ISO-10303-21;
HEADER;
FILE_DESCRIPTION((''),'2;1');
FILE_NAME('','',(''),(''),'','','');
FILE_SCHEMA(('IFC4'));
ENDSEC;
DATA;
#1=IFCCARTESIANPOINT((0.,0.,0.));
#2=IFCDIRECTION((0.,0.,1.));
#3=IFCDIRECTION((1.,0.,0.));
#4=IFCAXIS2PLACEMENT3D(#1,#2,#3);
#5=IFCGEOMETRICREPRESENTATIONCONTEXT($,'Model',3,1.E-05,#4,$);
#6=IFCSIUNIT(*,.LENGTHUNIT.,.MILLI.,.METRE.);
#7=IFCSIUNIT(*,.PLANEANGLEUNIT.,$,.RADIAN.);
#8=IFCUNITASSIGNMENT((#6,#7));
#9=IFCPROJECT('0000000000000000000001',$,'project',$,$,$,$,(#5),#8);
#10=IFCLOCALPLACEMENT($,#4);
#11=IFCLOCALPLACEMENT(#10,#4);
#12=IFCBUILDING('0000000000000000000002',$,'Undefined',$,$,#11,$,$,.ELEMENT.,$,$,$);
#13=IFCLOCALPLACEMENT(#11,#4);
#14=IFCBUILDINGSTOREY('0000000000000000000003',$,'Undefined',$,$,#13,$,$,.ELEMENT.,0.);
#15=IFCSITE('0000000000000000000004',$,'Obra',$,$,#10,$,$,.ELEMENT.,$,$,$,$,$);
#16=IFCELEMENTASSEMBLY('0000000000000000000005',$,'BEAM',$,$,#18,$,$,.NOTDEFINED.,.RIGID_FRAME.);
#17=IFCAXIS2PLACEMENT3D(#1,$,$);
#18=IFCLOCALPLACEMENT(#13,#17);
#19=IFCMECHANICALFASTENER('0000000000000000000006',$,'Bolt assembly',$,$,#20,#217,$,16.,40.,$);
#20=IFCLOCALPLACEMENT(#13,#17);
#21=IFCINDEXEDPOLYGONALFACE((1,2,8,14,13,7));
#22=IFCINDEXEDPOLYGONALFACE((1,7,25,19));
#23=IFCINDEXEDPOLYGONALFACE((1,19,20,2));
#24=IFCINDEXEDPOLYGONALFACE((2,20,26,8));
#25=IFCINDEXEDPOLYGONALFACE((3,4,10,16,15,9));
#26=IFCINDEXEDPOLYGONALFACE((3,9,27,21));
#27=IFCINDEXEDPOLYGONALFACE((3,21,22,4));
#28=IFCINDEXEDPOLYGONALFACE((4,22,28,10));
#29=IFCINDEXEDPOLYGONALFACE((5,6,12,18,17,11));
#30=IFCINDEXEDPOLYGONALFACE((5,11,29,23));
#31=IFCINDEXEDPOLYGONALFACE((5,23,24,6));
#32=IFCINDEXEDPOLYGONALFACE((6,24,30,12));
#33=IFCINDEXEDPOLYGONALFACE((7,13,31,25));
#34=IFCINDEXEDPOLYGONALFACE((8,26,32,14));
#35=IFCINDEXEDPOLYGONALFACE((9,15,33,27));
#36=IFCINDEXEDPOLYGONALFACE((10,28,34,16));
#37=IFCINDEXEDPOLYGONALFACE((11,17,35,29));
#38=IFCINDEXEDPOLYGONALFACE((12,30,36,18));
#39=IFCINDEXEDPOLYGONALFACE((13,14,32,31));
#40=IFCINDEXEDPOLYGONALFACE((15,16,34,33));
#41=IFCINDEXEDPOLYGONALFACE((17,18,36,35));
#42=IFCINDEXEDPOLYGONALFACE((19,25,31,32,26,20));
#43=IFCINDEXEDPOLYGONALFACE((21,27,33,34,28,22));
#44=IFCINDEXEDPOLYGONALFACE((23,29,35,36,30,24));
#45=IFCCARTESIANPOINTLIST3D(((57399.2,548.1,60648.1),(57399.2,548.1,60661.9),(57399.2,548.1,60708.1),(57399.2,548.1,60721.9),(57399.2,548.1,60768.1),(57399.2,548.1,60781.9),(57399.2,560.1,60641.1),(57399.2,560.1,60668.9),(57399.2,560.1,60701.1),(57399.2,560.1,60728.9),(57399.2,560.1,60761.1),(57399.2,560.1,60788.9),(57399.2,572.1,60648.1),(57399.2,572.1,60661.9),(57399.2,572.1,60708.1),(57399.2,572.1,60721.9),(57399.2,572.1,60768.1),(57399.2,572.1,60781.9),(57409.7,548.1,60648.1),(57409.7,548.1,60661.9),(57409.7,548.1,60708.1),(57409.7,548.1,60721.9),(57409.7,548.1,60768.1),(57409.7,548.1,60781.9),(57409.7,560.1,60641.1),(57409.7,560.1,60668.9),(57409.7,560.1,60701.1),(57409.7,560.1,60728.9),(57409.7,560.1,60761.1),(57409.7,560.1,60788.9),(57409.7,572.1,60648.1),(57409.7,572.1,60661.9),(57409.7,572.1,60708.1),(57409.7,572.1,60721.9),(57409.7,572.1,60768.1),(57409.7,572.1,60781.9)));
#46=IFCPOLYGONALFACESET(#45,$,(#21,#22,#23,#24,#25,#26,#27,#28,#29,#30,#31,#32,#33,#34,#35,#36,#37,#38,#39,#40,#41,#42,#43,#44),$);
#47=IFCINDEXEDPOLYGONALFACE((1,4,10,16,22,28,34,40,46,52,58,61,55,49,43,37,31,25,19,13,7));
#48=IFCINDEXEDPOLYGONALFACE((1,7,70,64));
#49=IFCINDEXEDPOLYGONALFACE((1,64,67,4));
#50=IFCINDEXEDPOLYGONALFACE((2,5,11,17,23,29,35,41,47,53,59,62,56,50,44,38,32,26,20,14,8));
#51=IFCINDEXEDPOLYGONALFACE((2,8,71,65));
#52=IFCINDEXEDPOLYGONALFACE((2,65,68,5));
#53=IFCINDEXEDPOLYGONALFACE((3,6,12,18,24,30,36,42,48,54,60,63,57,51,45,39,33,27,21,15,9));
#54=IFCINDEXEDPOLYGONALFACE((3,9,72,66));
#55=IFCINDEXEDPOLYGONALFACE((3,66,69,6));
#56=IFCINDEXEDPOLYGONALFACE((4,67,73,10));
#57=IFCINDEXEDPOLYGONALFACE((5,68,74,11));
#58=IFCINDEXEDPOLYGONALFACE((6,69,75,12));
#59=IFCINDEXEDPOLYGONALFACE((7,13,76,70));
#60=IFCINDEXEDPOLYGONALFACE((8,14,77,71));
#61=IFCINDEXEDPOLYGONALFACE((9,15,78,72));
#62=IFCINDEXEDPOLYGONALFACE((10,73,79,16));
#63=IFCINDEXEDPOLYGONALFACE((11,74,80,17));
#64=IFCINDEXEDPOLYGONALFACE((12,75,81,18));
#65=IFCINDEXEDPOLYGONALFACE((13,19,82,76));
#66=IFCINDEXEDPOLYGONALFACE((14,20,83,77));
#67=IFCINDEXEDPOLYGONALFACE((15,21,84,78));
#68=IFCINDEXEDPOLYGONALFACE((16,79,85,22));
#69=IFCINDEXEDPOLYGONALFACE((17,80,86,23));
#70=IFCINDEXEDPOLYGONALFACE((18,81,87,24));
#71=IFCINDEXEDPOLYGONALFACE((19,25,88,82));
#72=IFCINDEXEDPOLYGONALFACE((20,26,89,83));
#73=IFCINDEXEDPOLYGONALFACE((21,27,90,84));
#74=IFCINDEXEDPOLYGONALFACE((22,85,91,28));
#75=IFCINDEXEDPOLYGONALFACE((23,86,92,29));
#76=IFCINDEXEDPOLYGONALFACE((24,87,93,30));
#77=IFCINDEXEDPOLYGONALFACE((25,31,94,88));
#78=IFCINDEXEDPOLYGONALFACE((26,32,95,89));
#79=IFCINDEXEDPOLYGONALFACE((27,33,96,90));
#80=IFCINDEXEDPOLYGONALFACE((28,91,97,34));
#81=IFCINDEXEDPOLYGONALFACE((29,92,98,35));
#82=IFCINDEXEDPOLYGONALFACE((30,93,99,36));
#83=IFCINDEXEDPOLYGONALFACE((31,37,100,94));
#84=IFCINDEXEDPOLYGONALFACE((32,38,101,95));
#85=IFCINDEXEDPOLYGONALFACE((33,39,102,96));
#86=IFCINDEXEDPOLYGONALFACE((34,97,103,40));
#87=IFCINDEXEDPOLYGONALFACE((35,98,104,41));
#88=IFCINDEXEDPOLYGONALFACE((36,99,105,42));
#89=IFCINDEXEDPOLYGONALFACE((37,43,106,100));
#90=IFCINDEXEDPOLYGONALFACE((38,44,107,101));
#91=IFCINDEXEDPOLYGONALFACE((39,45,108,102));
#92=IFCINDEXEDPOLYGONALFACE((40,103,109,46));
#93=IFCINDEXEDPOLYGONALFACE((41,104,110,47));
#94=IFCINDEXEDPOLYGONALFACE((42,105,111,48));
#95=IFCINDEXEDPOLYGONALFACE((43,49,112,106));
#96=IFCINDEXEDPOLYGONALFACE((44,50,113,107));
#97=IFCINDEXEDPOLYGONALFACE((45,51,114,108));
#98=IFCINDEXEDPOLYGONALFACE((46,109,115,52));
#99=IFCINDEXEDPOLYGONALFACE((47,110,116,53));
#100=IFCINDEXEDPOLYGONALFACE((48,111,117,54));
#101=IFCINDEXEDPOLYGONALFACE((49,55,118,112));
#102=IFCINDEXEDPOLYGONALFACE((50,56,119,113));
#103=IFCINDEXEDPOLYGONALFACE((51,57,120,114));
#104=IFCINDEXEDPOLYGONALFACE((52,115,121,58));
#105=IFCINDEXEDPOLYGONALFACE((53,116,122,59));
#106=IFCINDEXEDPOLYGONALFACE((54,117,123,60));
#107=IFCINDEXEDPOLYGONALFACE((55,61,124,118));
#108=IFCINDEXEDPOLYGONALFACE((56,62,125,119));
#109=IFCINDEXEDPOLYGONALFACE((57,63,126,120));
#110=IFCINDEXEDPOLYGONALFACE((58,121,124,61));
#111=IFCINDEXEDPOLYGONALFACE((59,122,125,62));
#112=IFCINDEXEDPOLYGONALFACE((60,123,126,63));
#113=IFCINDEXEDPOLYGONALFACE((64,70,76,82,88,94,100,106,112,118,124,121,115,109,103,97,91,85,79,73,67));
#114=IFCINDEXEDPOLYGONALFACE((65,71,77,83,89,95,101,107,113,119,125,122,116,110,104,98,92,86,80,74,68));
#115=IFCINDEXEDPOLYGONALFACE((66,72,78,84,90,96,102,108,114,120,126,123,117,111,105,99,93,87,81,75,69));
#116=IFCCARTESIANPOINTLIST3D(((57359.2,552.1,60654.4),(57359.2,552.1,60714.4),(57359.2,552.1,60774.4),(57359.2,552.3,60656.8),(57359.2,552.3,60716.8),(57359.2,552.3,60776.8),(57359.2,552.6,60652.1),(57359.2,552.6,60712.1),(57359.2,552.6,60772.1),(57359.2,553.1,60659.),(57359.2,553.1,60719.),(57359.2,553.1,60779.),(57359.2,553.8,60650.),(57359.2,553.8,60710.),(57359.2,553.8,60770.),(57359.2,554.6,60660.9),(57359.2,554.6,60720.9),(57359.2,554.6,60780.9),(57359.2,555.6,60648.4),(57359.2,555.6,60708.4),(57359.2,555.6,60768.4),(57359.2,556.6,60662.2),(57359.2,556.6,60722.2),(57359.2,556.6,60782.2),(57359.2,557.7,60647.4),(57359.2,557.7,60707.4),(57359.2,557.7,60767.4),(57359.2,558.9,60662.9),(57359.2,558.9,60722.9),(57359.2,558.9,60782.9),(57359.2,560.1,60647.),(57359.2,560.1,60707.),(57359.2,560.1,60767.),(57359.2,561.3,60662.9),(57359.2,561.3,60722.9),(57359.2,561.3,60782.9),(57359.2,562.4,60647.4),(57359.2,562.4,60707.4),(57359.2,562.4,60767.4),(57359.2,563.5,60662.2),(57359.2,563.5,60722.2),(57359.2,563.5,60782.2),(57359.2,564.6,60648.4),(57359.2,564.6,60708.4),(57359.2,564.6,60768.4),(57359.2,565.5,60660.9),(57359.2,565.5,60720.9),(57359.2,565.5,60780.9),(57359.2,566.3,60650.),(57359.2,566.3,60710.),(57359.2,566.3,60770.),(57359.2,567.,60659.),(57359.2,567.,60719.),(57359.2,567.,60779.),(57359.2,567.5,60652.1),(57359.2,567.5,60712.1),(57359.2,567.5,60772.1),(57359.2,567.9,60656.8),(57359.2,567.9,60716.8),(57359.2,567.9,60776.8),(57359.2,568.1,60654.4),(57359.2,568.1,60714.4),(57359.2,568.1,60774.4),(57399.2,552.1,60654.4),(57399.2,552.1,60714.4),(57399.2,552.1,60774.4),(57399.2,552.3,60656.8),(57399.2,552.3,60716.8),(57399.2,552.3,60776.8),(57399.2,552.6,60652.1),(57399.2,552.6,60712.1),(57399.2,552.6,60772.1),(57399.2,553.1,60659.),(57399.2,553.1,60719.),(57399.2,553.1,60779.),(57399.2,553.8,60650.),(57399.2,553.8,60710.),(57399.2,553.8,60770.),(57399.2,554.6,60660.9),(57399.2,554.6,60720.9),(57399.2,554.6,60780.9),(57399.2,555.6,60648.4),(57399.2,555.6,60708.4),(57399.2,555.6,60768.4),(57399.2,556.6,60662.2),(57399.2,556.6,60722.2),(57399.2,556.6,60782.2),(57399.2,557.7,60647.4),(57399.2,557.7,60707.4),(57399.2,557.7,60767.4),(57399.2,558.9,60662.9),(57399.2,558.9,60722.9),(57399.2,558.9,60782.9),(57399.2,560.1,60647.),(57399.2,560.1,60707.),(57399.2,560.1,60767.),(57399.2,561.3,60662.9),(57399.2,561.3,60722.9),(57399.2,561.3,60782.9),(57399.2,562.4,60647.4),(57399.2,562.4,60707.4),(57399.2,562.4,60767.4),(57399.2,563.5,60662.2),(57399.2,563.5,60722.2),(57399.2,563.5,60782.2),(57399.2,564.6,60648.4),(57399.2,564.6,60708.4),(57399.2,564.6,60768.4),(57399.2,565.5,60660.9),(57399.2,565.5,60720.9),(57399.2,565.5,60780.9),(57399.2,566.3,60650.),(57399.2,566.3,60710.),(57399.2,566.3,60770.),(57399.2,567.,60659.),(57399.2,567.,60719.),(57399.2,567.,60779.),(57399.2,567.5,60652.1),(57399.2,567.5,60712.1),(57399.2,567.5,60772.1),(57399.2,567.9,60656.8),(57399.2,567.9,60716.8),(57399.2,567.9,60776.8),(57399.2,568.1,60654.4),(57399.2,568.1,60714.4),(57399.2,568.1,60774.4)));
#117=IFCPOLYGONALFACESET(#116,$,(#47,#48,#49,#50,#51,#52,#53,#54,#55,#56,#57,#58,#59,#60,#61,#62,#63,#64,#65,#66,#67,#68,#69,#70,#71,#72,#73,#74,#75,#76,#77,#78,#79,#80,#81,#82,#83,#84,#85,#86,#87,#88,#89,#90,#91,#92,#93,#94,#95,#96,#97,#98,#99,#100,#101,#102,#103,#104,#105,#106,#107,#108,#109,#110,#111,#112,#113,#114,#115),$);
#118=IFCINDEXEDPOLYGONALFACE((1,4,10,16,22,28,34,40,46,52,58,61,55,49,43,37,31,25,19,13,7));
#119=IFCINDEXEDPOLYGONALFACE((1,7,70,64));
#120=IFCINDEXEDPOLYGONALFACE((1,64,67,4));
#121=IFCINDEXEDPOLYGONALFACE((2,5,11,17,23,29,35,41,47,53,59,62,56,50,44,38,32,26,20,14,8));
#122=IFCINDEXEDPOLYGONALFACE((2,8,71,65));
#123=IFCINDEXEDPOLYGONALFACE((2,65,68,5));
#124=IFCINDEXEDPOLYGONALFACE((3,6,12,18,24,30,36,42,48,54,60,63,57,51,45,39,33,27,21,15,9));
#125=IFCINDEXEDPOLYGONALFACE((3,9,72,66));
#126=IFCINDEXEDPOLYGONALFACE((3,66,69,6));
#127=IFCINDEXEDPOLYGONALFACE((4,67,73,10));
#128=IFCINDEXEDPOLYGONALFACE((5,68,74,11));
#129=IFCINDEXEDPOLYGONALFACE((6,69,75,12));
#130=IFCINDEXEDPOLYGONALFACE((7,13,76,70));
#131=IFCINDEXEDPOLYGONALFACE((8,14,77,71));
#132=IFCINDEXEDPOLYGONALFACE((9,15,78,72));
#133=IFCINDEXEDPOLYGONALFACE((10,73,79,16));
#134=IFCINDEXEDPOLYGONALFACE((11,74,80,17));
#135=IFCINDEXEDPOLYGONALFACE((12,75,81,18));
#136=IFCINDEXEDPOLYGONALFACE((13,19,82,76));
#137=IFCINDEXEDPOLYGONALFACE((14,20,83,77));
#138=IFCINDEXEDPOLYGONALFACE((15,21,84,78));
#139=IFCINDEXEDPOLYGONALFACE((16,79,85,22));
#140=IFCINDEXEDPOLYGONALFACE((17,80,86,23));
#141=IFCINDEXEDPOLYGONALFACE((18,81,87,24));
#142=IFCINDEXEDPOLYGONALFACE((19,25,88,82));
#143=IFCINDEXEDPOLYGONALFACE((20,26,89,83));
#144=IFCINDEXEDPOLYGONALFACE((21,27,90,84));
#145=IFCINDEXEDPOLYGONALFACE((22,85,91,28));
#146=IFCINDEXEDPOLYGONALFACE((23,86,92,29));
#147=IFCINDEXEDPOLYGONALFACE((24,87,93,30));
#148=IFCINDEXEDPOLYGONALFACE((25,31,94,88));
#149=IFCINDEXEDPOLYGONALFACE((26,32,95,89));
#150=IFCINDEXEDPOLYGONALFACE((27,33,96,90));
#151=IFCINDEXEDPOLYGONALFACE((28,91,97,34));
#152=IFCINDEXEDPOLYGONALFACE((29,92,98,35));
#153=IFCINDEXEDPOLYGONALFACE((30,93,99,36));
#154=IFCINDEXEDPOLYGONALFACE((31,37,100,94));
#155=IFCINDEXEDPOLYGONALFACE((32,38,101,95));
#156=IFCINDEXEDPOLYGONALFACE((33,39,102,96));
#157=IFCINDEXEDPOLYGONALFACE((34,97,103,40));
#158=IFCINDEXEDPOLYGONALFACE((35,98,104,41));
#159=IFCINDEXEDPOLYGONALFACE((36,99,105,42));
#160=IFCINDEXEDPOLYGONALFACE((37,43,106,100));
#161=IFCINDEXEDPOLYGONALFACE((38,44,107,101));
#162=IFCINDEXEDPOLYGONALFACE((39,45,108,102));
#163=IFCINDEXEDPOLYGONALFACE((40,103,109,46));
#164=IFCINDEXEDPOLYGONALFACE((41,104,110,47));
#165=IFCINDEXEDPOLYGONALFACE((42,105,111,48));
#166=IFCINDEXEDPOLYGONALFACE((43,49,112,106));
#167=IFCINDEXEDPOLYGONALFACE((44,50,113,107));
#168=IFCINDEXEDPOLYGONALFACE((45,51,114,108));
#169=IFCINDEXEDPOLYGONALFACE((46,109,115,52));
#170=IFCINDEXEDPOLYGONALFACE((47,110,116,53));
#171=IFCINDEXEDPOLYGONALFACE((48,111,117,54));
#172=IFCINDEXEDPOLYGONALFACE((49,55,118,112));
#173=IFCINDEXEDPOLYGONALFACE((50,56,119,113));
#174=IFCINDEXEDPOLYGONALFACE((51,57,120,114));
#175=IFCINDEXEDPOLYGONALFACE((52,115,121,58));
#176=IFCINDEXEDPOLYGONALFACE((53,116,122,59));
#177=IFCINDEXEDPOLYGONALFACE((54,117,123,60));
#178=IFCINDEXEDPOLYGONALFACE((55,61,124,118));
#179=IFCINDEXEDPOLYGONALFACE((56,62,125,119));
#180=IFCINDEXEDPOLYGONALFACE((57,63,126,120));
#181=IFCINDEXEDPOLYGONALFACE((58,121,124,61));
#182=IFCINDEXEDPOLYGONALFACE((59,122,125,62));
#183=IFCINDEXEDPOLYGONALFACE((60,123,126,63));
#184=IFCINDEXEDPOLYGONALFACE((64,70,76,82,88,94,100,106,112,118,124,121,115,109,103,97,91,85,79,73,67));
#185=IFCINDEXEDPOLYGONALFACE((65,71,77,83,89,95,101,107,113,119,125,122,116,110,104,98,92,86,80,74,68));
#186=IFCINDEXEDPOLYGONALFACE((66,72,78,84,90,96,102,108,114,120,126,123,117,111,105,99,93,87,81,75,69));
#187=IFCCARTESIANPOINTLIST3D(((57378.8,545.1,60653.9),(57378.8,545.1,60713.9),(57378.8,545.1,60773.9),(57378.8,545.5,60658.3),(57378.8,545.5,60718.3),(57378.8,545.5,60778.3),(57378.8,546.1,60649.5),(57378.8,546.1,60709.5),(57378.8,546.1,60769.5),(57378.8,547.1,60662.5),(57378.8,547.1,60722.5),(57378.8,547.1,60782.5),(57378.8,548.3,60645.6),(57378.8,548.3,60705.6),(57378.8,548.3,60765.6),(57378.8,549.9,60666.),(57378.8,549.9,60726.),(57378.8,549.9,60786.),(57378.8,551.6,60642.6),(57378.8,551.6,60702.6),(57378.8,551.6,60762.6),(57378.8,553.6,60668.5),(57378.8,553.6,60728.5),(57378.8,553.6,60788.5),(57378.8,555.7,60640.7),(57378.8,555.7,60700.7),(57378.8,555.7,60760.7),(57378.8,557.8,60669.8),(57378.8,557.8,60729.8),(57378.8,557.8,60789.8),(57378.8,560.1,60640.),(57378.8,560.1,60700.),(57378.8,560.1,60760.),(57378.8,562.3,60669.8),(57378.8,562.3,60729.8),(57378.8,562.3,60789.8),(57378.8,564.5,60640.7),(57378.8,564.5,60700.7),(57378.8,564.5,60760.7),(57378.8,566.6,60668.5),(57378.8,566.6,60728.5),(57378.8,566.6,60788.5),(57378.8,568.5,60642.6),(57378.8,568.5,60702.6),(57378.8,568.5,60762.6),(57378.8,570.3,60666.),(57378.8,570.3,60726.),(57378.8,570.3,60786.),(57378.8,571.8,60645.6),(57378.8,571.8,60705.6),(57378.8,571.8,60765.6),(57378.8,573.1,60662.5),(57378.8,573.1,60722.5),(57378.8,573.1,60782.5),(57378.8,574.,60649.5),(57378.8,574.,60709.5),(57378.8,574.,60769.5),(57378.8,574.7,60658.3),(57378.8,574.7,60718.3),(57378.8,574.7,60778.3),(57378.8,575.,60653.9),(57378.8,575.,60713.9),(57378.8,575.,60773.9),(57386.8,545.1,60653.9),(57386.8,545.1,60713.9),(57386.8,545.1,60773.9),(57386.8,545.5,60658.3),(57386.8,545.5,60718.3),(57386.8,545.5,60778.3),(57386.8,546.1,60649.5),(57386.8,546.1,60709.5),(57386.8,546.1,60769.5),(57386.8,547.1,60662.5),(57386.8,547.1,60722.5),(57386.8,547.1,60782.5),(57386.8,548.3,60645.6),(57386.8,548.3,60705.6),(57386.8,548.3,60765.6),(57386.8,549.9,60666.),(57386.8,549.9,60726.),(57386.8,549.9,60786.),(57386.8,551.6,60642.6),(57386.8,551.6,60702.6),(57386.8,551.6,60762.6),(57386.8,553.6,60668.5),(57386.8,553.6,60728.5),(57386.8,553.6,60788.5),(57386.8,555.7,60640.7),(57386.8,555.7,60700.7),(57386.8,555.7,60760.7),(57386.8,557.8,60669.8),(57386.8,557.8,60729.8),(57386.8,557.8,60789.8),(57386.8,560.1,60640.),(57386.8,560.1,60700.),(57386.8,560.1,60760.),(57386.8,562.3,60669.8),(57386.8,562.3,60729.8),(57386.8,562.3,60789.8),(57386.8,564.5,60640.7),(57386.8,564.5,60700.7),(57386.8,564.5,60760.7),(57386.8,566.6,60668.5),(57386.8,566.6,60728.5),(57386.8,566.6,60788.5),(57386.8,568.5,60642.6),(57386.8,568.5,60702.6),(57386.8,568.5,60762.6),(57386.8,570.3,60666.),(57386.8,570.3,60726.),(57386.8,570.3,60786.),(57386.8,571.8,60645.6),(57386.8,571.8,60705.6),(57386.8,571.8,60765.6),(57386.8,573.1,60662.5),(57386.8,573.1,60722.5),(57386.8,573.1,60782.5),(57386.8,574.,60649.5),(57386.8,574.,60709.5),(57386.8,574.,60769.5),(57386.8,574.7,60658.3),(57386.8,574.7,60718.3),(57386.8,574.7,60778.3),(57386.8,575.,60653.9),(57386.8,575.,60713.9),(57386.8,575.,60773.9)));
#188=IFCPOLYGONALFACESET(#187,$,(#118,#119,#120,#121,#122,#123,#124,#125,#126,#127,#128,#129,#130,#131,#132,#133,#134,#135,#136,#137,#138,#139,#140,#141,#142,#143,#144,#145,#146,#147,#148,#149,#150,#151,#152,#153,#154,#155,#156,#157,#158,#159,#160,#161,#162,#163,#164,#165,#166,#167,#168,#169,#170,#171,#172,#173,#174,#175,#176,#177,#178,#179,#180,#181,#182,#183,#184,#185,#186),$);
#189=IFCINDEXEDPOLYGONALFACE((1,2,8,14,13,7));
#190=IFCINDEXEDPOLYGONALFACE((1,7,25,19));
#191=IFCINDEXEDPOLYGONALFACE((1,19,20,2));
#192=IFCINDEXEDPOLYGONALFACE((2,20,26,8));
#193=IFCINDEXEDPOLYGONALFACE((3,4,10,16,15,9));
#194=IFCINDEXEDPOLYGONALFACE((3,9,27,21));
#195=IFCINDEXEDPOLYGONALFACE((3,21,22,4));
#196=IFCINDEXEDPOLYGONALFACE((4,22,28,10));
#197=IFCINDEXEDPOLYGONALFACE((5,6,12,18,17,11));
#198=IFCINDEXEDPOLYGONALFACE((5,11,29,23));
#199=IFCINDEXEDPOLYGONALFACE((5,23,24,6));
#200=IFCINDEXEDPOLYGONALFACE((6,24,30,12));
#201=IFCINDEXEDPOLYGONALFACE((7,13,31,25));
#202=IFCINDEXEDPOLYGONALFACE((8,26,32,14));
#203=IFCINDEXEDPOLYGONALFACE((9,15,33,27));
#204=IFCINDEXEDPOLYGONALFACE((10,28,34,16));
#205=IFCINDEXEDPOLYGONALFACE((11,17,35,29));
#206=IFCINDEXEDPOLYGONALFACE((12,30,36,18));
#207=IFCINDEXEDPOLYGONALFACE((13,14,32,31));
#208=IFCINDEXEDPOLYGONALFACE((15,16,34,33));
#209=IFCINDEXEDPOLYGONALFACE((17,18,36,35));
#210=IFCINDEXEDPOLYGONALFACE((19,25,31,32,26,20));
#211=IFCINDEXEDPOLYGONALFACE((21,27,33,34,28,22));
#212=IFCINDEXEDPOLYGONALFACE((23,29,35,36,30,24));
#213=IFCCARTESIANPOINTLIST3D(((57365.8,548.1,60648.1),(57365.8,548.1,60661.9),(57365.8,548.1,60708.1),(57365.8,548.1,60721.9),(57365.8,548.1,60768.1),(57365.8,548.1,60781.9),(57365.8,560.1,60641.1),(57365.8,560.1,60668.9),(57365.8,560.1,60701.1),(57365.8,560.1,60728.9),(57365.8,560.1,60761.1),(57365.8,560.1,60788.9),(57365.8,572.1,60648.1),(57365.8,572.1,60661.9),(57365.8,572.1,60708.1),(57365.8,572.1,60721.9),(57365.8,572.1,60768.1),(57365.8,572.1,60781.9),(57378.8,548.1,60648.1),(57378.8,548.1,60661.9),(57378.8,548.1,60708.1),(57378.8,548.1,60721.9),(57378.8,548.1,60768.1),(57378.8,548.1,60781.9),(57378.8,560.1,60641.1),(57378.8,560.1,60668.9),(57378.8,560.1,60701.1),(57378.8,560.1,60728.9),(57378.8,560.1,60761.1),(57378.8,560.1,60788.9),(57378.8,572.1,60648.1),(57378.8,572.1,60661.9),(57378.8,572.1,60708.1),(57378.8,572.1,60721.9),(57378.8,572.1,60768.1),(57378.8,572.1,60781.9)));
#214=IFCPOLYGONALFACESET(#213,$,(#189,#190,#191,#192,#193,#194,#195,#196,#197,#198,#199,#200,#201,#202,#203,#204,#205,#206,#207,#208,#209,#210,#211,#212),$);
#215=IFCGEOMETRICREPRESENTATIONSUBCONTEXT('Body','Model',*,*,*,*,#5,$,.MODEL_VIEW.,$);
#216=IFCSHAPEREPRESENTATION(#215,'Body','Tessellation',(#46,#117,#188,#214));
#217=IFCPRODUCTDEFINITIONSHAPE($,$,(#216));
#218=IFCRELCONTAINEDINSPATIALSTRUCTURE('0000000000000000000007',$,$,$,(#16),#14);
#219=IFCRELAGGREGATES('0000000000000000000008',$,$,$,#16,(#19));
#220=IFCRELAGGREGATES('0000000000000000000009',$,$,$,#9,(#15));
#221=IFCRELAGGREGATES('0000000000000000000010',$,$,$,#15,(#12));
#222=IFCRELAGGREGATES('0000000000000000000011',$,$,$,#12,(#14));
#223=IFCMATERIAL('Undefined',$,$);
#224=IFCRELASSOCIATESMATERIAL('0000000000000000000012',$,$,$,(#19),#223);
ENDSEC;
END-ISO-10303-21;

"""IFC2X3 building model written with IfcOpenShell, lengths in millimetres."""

from ifc_helpers import new_model, si_unit, frame, origin_with_axes, origin_2d_with_axis, place, context, subcontext, project, spatial, polyline, circle, outline, extrude, source, transform, mapped, material, element, aggregate, save


model = new_model("IFC2X3")

# Units and contexts
model_context = context("Model", 3, precision=1e-05, world=origin_with_axes())
body_context = subcontext(model_context, "Body", "Model", "MODEL_VIEW")
ifc_project = project(units=[si_unit("LENGTHUNIT", "METRE", prefix="MILLI"), si_unit("PLANEANGLEUNIT", "RADIAN")], contexts=[model_context])

# Site, building, storey
site_placement = place(None, origin_with_axes())
site = spatial("IfcSite", under=ifc_project, at=site_placement, Name="Obra", CompositionType="ELEMENT")
building_placement = place(site_placement, origin_with_axes())
building = spatial("IfcBuilding", under=site, at=building_placement, Name="Undefined", CompositionType="ELEMENT")
storey_placement = place(building_placement, origin_with_axes())
storey = spatial("IfcBuildingStorey", under=building, at=storey_placement, Name="Undefined", CompositionType="ELEMENT", Elevation=0.0)

# Element assembly
ifc_material_1 = material(Name="Undefined")
assembly_1_placement = place(storey_placement, origin_with_axes())
assembly_1 = element("IfcElementAssembly", 1, at=assembly_1_placement, inside=storey, Name="BEAM", AssemblyPlace="NOTDEFINED", PredefinedType="RIGID_FRAME")

# Mechanical fastener
shared_shape_1 = source(origin_with_axes(), body_context, "Body", "SweptSolid", [
    extrude(outline(polyline([(13.9, 0.0), (6.9, 12.0), (-6.9, 12.0), (-13.9, 0.0), (-6.9, -12.0), (6.9, -12.0), (13.9, 0.0)])), frame((0.0, -19.7, 0.0), z_axis=(0.0, 1.0, 0.0), x_axis=(1.0, 0.0, 0.0)), (0.0, 0.0, 1.0), 10.6),
    extrude(circle(Radius=8.0, at=origin_2d_with_axis()), frame((0.0, -9.1, 0.0), z_axis=(0.0, 1.0, 0.0), x_axis=(1.0, 0.0, 0.0)), (0.0, 0.0, 1.0), 40.0),
    extrude(circle(Radius=15.0, at=origin_2d_with_axis()), frame((0.0, 3.3, 0.0), z_axis=(0.0, 1.0, 0.0), x_axis=(1.0, 0.0, 0.0)), (0.0, 0.0, 1.0), 8.0),
    extrude(outline(polyline([(13.9, 0.0), (6.9, 12.0), (-6.9, 12.0), (-13.9, 0.0), (-6.9, -12.0), (6.9, -12.0), (13.9, 0.0)])), frame((0.0, 11.3, 0.0), z_axis=(0.0, 1.0, 0.0), x_axis=(1.0, 0.0, 0.0)), (0.0, 0.0, 1.0), 13.0),
])
mechanical_fastener_1_placement = place(assembly_1_placement, frame((57390.1, 510.1, 60835.0), z_axis=(-0.000002, 1.0, 0.0), x_axis=(0.0, 0.0, -1.0)))
mechanical_fastener_1 = element("IfcMechanicalFastener", 2, at=mechanical_fastener_1_placement, material=ifc_material_1, Name="Bolt assembly", NominalDiameter=16.0, NominalLength=40.0, context=body_context, shape_type="MappedRepresentation", body=[
    mapped(shared_shape_1, transform((60.0, 0.0, 50.0))),
    mapped(shared_shape_1, transform((120.0, 0.0, 50.0))),
    mapped(shared_shape_1, transform((180.0, 0.0, 50.0))),
])
aggregate(assembly_1, [mechanical_fastener_1])

save(model, "model.ifc")
